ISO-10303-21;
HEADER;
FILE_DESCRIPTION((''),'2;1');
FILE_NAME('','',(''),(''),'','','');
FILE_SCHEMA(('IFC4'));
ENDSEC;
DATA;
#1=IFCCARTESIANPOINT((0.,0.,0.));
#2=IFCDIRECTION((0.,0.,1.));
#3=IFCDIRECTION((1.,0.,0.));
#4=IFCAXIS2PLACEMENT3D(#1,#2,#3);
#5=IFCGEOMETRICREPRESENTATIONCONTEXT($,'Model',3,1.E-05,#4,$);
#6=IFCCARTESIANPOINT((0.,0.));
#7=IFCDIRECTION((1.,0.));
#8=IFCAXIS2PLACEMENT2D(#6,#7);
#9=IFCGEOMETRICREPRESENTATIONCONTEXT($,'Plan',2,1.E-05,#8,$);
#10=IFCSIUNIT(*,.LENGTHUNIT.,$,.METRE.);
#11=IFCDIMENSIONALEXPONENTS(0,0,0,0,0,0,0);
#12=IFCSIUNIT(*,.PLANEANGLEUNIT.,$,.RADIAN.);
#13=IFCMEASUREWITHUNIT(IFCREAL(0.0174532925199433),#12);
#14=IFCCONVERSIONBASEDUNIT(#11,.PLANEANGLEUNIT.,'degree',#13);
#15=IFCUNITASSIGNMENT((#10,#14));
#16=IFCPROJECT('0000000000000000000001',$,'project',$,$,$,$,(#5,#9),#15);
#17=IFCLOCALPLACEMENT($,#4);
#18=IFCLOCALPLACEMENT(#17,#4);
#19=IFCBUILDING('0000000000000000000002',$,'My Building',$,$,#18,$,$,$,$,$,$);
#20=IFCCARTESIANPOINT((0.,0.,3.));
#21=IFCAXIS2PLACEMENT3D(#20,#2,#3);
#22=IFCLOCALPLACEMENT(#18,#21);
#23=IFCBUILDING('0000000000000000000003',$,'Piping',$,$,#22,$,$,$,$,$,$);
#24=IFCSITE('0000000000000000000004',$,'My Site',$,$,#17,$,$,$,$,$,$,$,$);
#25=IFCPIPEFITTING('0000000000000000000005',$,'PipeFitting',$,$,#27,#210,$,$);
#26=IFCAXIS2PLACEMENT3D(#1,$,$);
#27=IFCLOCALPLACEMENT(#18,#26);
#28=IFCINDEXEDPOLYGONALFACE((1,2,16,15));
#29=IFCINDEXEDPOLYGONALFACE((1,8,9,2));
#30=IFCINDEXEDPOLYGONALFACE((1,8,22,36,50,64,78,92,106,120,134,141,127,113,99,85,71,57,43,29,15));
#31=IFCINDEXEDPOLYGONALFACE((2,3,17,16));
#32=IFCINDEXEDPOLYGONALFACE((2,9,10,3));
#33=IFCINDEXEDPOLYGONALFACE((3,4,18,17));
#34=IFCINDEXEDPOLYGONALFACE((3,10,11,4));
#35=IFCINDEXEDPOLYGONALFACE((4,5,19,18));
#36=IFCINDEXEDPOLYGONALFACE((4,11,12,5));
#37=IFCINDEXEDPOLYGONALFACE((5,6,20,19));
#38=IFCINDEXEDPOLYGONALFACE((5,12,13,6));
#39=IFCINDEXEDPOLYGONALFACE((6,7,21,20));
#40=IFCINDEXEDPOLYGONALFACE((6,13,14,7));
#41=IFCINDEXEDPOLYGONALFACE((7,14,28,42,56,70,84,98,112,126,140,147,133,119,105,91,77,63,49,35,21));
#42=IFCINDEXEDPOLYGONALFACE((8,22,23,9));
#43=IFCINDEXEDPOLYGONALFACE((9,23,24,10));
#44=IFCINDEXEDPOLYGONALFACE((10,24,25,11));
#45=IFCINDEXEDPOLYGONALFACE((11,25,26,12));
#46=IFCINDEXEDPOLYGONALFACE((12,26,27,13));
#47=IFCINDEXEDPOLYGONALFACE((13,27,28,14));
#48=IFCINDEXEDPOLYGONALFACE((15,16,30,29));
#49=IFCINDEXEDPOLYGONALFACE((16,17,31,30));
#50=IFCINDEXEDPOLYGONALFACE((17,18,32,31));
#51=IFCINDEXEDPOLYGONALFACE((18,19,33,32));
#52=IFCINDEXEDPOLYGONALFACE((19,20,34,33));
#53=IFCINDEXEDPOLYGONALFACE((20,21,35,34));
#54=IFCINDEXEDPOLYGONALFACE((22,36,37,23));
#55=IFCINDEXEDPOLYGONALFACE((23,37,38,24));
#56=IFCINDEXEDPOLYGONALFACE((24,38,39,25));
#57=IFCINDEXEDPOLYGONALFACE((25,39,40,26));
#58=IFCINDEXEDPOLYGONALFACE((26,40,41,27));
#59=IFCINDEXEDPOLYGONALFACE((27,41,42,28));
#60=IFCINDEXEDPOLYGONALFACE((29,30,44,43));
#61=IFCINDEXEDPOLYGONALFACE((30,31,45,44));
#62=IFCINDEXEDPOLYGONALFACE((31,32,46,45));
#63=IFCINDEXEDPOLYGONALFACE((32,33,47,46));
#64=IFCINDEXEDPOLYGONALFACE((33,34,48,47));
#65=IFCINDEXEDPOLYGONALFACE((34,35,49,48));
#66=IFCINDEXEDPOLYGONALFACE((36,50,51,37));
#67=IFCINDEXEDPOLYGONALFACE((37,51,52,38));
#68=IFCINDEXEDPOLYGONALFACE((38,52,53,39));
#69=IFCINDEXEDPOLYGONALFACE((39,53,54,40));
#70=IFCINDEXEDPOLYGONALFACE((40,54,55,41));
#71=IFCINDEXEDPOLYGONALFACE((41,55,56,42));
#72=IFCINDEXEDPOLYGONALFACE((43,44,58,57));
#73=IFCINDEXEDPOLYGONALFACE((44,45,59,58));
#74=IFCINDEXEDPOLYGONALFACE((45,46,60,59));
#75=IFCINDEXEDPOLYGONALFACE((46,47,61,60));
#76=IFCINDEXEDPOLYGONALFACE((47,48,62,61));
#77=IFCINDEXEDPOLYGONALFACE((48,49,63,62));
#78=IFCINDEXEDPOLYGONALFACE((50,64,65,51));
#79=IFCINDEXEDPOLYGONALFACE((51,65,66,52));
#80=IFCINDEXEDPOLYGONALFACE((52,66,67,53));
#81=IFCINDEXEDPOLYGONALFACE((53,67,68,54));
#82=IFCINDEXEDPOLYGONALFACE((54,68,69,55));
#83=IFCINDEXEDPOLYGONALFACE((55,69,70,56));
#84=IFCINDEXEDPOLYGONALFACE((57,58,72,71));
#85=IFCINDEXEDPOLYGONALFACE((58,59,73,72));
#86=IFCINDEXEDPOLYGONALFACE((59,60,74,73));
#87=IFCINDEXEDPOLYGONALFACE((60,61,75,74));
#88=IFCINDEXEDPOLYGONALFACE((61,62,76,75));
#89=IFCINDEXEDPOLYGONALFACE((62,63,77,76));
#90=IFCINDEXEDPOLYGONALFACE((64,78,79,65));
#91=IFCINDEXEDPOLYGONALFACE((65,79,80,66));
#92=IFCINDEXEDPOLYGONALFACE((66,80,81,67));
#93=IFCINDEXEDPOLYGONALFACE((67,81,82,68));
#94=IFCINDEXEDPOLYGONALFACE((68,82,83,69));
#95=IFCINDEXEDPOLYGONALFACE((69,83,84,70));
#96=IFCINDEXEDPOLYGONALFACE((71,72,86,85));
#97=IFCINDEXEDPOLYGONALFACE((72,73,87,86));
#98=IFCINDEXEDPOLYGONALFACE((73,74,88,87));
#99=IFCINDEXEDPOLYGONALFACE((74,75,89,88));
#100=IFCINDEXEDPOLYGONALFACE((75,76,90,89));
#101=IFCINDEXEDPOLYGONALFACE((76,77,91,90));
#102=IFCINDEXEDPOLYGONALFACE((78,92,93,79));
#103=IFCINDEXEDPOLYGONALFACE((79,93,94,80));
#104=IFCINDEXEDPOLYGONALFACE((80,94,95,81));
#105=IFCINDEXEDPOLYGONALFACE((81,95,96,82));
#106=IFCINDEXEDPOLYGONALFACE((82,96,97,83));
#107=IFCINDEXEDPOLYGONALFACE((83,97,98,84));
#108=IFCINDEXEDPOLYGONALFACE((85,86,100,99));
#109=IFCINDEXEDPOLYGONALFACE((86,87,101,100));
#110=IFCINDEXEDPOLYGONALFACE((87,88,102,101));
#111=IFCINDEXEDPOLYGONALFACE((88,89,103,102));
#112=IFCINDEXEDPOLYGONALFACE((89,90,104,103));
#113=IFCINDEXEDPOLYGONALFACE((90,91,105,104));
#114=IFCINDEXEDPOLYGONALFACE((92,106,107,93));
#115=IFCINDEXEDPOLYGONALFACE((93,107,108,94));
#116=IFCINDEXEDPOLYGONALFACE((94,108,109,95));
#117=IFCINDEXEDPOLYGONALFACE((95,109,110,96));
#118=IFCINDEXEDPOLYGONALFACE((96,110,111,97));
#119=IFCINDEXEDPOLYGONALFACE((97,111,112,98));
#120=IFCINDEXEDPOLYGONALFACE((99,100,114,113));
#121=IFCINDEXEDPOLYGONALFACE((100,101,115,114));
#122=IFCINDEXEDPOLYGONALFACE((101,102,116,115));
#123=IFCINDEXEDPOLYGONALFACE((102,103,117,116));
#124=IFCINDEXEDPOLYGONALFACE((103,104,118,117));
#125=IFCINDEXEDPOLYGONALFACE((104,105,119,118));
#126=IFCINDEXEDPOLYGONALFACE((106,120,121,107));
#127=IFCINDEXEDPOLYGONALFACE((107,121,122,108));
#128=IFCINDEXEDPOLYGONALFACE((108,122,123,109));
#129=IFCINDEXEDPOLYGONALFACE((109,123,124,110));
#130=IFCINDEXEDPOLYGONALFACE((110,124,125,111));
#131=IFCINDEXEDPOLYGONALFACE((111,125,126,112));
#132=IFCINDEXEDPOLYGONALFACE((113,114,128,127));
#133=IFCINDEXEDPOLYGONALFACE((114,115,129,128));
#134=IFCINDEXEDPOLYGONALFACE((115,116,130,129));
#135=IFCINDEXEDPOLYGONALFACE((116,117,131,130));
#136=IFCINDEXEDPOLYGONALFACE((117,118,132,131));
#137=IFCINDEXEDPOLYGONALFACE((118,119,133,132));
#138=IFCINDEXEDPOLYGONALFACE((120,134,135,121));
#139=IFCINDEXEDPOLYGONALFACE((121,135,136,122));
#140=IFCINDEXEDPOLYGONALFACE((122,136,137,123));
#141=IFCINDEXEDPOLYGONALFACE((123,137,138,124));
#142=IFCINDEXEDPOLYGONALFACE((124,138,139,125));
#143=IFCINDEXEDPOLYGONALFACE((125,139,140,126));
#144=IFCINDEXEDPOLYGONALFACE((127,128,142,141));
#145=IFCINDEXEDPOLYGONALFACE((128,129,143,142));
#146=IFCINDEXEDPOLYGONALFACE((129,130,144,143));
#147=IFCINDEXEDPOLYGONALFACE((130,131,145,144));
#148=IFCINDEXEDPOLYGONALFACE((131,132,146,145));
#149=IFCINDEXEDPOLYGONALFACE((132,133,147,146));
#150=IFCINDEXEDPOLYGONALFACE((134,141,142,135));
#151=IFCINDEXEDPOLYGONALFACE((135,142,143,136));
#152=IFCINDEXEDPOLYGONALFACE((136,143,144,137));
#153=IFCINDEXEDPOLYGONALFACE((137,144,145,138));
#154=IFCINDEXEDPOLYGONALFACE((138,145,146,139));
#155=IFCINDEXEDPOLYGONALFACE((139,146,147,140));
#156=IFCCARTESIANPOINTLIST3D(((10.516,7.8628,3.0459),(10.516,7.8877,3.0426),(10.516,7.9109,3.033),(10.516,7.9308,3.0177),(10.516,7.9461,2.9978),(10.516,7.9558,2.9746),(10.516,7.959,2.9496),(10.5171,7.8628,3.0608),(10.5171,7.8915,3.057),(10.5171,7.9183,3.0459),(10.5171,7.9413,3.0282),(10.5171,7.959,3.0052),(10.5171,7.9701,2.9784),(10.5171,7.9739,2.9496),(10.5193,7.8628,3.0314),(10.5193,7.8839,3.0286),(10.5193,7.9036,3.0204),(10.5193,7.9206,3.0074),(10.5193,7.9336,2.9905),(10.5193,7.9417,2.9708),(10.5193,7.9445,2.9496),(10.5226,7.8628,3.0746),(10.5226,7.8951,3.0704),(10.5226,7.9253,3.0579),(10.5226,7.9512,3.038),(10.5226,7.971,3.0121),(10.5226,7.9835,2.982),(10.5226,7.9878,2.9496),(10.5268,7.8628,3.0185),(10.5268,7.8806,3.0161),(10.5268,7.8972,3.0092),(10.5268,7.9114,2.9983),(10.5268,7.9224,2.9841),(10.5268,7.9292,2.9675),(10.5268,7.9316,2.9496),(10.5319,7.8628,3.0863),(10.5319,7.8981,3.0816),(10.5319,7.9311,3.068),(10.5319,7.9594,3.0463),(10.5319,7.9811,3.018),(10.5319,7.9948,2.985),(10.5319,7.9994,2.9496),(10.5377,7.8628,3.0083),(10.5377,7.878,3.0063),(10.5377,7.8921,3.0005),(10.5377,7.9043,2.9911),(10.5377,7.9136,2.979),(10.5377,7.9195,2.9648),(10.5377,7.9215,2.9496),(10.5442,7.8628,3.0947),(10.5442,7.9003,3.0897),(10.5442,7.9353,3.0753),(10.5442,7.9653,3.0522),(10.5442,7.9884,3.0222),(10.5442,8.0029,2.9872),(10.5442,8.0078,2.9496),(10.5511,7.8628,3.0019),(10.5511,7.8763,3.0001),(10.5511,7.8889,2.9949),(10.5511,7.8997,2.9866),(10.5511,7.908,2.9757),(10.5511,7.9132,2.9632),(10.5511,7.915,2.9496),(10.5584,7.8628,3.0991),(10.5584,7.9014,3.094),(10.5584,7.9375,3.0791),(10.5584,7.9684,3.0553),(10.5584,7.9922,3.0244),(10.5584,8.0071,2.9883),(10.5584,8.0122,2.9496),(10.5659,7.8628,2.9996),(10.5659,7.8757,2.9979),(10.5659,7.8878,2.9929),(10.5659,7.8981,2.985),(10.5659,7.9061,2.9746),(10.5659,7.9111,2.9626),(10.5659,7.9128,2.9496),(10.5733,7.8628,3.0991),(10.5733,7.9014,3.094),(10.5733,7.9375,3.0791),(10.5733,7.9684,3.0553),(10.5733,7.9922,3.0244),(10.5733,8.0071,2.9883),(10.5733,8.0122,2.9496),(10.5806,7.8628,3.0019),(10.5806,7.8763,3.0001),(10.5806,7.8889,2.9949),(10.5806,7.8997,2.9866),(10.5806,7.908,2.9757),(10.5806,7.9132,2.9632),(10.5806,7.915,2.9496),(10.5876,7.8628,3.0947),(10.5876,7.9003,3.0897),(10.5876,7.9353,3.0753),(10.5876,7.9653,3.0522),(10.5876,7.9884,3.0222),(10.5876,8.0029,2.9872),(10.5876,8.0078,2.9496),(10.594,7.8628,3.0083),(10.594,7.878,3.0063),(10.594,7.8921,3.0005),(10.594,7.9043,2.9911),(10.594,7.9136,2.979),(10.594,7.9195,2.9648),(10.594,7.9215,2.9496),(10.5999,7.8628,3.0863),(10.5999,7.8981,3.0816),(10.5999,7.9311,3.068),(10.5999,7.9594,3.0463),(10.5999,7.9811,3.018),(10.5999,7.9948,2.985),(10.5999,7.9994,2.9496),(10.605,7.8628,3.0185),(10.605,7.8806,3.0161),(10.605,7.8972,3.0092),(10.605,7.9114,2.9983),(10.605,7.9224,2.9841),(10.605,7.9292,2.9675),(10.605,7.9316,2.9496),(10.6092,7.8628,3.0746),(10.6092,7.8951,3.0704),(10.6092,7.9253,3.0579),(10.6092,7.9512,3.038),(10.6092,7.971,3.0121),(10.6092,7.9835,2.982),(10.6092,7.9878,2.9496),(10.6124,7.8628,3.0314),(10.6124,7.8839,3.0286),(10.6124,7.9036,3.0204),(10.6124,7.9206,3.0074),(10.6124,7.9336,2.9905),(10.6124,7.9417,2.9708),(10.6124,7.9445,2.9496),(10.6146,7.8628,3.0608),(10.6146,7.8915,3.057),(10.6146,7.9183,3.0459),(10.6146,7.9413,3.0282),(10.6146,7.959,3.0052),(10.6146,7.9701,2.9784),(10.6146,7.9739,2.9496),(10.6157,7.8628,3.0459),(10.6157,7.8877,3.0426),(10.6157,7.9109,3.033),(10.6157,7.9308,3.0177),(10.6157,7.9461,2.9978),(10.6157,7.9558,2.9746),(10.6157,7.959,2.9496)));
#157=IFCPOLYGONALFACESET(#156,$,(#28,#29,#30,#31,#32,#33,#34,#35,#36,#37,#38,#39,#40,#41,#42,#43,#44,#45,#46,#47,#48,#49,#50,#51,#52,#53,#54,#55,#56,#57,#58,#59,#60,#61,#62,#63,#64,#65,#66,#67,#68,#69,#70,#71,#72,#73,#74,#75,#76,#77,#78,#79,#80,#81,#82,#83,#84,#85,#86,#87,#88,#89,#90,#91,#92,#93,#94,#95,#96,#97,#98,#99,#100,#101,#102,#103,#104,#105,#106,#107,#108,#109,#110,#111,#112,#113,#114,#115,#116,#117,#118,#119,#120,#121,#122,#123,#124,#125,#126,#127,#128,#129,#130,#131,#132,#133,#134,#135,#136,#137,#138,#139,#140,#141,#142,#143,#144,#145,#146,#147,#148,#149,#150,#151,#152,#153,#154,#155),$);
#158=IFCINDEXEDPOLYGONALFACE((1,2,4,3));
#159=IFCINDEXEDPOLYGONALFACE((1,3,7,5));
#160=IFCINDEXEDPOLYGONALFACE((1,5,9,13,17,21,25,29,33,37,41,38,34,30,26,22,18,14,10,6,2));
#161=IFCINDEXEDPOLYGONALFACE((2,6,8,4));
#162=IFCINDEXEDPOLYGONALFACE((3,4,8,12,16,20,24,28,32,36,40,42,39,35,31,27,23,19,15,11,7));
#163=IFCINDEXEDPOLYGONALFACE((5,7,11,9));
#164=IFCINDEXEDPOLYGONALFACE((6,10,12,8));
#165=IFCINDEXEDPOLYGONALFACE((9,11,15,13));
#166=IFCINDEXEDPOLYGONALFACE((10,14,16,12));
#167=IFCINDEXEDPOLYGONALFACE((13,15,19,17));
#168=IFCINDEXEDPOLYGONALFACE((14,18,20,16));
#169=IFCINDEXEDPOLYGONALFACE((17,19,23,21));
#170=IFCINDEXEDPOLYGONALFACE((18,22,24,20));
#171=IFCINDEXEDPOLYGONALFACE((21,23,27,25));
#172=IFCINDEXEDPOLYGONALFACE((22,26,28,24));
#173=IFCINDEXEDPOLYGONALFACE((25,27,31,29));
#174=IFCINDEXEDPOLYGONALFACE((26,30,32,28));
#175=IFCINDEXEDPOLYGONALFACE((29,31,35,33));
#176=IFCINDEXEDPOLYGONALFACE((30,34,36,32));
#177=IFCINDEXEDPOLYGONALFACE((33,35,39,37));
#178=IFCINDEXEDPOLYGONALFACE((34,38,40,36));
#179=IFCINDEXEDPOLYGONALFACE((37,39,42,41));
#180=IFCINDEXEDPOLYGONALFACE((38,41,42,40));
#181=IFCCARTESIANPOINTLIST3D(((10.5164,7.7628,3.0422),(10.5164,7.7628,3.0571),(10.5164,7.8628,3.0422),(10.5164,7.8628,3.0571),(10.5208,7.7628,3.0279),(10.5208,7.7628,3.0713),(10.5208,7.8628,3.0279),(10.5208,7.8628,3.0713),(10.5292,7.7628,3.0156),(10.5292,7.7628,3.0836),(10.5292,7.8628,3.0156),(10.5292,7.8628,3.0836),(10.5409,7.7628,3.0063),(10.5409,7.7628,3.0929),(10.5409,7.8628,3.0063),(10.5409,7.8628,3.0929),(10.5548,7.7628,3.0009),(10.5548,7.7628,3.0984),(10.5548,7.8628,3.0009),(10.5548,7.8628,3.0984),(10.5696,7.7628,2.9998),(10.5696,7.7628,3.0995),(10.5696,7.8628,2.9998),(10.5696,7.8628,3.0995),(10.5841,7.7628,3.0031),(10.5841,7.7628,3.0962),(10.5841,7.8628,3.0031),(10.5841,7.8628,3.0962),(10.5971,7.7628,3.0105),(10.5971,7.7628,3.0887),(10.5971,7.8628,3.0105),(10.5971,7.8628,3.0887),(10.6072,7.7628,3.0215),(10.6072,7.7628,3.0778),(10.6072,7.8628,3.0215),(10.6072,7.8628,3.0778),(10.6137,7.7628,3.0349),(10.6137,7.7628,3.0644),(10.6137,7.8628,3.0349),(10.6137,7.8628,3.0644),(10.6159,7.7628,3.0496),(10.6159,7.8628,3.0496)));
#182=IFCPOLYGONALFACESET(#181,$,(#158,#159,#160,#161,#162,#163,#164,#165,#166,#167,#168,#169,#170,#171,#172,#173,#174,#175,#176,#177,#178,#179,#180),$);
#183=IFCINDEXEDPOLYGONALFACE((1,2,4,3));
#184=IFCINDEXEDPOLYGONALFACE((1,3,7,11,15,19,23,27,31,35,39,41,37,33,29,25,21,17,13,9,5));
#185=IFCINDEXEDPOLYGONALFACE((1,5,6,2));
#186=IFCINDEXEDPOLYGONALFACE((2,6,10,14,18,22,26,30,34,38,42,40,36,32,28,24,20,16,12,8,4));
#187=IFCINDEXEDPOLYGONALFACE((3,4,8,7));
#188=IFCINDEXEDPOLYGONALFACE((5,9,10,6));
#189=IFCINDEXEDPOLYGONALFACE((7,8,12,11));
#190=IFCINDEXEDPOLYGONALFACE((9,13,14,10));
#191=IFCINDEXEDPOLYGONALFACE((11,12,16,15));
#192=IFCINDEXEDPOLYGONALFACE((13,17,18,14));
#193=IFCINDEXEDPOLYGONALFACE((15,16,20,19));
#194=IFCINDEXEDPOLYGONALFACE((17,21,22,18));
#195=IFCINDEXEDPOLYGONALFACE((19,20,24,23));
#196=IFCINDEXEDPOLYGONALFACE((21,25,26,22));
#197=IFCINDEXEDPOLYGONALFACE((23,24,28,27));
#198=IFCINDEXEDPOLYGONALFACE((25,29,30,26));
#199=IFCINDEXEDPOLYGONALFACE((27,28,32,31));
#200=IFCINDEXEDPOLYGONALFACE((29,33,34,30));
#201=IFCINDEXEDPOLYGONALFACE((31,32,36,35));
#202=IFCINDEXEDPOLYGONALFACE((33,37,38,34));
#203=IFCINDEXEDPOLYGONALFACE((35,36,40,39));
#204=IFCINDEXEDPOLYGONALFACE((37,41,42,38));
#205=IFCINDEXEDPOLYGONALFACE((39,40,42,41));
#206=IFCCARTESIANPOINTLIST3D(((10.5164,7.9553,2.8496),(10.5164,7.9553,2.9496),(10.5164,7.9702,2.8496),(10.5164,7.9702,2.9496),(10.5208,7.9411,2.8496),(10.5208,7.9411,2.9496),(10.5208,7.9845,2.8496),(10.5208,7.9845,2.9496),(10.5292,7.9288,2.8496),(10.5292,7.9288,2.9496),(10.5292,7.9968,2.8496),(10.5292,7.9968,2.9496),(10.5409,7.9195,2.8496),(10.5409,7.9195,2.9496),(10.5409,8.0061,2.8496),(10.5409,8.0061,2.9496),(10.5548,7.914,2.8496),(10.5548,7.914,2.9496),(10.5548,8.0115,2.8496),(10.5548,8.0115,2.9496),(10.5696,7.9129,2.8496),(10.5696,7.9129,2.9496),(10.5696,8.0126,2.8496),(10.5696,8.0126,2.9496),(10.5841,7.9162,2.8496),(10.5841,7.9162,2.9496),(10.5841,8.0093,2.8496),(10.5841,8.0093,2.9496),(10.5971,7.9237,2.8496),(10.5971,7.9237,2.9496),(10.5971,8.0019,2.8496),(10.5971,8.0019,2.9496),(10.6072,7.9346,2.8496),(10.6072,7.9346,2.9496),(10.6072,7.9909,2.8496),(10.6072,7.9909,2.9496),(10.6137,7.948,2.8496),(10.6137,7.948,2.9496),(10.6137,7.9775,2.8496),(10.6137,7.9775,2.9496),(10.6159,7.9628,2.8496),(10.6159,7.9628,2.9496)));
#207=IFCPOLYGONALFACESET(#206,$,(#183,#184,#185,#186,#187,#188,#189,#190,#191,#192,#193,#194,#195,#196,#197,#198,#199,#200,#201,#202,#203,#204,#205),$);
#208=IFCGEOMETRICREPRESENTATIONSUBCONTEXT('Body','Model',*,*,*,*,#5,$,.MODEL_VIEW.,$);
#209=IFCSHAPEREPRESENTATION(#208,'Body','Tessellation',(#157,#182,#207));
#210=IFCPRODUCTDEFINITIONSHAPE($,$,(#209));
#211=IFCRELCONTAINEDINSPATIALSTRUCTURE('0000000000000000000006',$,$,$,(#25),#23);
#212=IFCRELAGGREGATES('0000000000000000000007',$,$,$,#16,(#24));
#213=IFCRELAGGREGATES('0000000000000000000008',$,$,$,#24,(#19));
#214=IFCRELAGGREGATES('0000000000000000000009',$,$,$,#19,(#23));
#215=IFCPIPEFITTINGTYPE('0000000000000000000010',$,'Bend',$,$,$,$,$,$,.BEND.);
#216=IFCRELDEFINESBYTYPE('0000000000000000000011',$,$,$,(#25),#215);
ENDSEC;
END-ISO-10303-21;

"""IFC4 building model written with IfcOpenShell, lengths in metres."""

from ifc_helpers import new_model, entity, si_unit, converted_unit, frame, origin_with_axes, origin_2d_with_axis, place, context, subcontext, project, spatial, circle, extrude, source, transform, mapped, type_object, type_shapes, element, save


model = new_model("IFC4")

# Units and contexts
model_context = context("Model", 3, precision=1e-05, world=origin_with_axes())
plan_context = context("Plan", 2, precision=1e-05, world=origin_2d_with_axis())
body_context = subcontext(model_context, "Body", "Model", "MODEL_VIEW")
ifc_project = project(units=[si_unit("LENGTHUNIT", "METRE"), converted_unit("PLANEANGLEUNIT", "degree", entity("IfcReal", 0.0174532925199433), si_unit("PLANEANGLEUNIT", "RADIAN"), dimensions=[0, 0, 0, 0, 0, 0, 0])], contexts=[model_context, plan_context])

# Site, buildings
site_placement = place(None, origin_with_axes())
site = spatial("IfcSite", under=ifc_project, at=site_placement, Name="My Site")
building_1_placement = place(site_placement, origin_with_axes())
building_1 = spatial("IfcBuilding", under=site, at=building_1_placement, Name="My Building")
building_2_placement = place(building_1_placement, frame((0.0, 0.0, 3.0), z_axis=(0.0, 0.0, 1.0), x_axis=(1.0, 0.0, 0.0)))
building_2 = spatial("IfcBuilding", under=building_1, at=building_2_placement, Name="Piping")

# Pipe fitting
pipe_fitting_type_1 = type_object("IfcPipeFittingType", Name="Bend", PredefinedType="BEND")
shared_shape = source(origin_with_axes(), body_context, "Body", "SolidModel", [
    entity("IfcSweptDiskSolid", entity("IfcIndexedPolyCurve", entity("IfcCartesianPointList3D", [[0.0, 0.0, 0.1], [0.0, 0.0293, 0.1707], [0.0, 0.1, 0.2]]), [entity("IfcArcIndex", [1, 2, 3])]), 0.05),
    extrude(circle(Radius=0.05), origin_with_axes(), (0.0, 0.0, 1.0), 0.1),
    extrude(circle(Radius=0.05), frame((0.0, 0.1, 0.2), z_axis=(0.0, 1.0, 0.0), x_axis=(1.0, 0.0, 0.0)), (0.0, 0.0, 1.0), 0.1),
])
type_shapes(pipe_fitting_type_1, [shared_shape])
for number, where, z_axis, x_axis, name in (
    (1, (10.5659, 7.7628, 0.0496), (0.0, 1.0, 0.0), (1.0, 0.0, 0.0), "PipeFitting"),
):
    element("IfcPipeFitting", number, at=place(building_2_placement, frame(where, z_axis=z_axis, x_axis=x_axis)), inside=building_2, type_object=pipe_fitting_type_1, Name=name, context=body_context, shape_type="MappedRepresentation", body=[
        mapped(shared_shape, transform((0.0, 0.0, 0.0), x_axis=(1.0, 0.0, 0.0), y_axis=(0.0, 1.0, 0.0), z_axis=(0.0, 0.0, 1.0), scale=1.0)),
    ])

save(model, "model.ifc")
